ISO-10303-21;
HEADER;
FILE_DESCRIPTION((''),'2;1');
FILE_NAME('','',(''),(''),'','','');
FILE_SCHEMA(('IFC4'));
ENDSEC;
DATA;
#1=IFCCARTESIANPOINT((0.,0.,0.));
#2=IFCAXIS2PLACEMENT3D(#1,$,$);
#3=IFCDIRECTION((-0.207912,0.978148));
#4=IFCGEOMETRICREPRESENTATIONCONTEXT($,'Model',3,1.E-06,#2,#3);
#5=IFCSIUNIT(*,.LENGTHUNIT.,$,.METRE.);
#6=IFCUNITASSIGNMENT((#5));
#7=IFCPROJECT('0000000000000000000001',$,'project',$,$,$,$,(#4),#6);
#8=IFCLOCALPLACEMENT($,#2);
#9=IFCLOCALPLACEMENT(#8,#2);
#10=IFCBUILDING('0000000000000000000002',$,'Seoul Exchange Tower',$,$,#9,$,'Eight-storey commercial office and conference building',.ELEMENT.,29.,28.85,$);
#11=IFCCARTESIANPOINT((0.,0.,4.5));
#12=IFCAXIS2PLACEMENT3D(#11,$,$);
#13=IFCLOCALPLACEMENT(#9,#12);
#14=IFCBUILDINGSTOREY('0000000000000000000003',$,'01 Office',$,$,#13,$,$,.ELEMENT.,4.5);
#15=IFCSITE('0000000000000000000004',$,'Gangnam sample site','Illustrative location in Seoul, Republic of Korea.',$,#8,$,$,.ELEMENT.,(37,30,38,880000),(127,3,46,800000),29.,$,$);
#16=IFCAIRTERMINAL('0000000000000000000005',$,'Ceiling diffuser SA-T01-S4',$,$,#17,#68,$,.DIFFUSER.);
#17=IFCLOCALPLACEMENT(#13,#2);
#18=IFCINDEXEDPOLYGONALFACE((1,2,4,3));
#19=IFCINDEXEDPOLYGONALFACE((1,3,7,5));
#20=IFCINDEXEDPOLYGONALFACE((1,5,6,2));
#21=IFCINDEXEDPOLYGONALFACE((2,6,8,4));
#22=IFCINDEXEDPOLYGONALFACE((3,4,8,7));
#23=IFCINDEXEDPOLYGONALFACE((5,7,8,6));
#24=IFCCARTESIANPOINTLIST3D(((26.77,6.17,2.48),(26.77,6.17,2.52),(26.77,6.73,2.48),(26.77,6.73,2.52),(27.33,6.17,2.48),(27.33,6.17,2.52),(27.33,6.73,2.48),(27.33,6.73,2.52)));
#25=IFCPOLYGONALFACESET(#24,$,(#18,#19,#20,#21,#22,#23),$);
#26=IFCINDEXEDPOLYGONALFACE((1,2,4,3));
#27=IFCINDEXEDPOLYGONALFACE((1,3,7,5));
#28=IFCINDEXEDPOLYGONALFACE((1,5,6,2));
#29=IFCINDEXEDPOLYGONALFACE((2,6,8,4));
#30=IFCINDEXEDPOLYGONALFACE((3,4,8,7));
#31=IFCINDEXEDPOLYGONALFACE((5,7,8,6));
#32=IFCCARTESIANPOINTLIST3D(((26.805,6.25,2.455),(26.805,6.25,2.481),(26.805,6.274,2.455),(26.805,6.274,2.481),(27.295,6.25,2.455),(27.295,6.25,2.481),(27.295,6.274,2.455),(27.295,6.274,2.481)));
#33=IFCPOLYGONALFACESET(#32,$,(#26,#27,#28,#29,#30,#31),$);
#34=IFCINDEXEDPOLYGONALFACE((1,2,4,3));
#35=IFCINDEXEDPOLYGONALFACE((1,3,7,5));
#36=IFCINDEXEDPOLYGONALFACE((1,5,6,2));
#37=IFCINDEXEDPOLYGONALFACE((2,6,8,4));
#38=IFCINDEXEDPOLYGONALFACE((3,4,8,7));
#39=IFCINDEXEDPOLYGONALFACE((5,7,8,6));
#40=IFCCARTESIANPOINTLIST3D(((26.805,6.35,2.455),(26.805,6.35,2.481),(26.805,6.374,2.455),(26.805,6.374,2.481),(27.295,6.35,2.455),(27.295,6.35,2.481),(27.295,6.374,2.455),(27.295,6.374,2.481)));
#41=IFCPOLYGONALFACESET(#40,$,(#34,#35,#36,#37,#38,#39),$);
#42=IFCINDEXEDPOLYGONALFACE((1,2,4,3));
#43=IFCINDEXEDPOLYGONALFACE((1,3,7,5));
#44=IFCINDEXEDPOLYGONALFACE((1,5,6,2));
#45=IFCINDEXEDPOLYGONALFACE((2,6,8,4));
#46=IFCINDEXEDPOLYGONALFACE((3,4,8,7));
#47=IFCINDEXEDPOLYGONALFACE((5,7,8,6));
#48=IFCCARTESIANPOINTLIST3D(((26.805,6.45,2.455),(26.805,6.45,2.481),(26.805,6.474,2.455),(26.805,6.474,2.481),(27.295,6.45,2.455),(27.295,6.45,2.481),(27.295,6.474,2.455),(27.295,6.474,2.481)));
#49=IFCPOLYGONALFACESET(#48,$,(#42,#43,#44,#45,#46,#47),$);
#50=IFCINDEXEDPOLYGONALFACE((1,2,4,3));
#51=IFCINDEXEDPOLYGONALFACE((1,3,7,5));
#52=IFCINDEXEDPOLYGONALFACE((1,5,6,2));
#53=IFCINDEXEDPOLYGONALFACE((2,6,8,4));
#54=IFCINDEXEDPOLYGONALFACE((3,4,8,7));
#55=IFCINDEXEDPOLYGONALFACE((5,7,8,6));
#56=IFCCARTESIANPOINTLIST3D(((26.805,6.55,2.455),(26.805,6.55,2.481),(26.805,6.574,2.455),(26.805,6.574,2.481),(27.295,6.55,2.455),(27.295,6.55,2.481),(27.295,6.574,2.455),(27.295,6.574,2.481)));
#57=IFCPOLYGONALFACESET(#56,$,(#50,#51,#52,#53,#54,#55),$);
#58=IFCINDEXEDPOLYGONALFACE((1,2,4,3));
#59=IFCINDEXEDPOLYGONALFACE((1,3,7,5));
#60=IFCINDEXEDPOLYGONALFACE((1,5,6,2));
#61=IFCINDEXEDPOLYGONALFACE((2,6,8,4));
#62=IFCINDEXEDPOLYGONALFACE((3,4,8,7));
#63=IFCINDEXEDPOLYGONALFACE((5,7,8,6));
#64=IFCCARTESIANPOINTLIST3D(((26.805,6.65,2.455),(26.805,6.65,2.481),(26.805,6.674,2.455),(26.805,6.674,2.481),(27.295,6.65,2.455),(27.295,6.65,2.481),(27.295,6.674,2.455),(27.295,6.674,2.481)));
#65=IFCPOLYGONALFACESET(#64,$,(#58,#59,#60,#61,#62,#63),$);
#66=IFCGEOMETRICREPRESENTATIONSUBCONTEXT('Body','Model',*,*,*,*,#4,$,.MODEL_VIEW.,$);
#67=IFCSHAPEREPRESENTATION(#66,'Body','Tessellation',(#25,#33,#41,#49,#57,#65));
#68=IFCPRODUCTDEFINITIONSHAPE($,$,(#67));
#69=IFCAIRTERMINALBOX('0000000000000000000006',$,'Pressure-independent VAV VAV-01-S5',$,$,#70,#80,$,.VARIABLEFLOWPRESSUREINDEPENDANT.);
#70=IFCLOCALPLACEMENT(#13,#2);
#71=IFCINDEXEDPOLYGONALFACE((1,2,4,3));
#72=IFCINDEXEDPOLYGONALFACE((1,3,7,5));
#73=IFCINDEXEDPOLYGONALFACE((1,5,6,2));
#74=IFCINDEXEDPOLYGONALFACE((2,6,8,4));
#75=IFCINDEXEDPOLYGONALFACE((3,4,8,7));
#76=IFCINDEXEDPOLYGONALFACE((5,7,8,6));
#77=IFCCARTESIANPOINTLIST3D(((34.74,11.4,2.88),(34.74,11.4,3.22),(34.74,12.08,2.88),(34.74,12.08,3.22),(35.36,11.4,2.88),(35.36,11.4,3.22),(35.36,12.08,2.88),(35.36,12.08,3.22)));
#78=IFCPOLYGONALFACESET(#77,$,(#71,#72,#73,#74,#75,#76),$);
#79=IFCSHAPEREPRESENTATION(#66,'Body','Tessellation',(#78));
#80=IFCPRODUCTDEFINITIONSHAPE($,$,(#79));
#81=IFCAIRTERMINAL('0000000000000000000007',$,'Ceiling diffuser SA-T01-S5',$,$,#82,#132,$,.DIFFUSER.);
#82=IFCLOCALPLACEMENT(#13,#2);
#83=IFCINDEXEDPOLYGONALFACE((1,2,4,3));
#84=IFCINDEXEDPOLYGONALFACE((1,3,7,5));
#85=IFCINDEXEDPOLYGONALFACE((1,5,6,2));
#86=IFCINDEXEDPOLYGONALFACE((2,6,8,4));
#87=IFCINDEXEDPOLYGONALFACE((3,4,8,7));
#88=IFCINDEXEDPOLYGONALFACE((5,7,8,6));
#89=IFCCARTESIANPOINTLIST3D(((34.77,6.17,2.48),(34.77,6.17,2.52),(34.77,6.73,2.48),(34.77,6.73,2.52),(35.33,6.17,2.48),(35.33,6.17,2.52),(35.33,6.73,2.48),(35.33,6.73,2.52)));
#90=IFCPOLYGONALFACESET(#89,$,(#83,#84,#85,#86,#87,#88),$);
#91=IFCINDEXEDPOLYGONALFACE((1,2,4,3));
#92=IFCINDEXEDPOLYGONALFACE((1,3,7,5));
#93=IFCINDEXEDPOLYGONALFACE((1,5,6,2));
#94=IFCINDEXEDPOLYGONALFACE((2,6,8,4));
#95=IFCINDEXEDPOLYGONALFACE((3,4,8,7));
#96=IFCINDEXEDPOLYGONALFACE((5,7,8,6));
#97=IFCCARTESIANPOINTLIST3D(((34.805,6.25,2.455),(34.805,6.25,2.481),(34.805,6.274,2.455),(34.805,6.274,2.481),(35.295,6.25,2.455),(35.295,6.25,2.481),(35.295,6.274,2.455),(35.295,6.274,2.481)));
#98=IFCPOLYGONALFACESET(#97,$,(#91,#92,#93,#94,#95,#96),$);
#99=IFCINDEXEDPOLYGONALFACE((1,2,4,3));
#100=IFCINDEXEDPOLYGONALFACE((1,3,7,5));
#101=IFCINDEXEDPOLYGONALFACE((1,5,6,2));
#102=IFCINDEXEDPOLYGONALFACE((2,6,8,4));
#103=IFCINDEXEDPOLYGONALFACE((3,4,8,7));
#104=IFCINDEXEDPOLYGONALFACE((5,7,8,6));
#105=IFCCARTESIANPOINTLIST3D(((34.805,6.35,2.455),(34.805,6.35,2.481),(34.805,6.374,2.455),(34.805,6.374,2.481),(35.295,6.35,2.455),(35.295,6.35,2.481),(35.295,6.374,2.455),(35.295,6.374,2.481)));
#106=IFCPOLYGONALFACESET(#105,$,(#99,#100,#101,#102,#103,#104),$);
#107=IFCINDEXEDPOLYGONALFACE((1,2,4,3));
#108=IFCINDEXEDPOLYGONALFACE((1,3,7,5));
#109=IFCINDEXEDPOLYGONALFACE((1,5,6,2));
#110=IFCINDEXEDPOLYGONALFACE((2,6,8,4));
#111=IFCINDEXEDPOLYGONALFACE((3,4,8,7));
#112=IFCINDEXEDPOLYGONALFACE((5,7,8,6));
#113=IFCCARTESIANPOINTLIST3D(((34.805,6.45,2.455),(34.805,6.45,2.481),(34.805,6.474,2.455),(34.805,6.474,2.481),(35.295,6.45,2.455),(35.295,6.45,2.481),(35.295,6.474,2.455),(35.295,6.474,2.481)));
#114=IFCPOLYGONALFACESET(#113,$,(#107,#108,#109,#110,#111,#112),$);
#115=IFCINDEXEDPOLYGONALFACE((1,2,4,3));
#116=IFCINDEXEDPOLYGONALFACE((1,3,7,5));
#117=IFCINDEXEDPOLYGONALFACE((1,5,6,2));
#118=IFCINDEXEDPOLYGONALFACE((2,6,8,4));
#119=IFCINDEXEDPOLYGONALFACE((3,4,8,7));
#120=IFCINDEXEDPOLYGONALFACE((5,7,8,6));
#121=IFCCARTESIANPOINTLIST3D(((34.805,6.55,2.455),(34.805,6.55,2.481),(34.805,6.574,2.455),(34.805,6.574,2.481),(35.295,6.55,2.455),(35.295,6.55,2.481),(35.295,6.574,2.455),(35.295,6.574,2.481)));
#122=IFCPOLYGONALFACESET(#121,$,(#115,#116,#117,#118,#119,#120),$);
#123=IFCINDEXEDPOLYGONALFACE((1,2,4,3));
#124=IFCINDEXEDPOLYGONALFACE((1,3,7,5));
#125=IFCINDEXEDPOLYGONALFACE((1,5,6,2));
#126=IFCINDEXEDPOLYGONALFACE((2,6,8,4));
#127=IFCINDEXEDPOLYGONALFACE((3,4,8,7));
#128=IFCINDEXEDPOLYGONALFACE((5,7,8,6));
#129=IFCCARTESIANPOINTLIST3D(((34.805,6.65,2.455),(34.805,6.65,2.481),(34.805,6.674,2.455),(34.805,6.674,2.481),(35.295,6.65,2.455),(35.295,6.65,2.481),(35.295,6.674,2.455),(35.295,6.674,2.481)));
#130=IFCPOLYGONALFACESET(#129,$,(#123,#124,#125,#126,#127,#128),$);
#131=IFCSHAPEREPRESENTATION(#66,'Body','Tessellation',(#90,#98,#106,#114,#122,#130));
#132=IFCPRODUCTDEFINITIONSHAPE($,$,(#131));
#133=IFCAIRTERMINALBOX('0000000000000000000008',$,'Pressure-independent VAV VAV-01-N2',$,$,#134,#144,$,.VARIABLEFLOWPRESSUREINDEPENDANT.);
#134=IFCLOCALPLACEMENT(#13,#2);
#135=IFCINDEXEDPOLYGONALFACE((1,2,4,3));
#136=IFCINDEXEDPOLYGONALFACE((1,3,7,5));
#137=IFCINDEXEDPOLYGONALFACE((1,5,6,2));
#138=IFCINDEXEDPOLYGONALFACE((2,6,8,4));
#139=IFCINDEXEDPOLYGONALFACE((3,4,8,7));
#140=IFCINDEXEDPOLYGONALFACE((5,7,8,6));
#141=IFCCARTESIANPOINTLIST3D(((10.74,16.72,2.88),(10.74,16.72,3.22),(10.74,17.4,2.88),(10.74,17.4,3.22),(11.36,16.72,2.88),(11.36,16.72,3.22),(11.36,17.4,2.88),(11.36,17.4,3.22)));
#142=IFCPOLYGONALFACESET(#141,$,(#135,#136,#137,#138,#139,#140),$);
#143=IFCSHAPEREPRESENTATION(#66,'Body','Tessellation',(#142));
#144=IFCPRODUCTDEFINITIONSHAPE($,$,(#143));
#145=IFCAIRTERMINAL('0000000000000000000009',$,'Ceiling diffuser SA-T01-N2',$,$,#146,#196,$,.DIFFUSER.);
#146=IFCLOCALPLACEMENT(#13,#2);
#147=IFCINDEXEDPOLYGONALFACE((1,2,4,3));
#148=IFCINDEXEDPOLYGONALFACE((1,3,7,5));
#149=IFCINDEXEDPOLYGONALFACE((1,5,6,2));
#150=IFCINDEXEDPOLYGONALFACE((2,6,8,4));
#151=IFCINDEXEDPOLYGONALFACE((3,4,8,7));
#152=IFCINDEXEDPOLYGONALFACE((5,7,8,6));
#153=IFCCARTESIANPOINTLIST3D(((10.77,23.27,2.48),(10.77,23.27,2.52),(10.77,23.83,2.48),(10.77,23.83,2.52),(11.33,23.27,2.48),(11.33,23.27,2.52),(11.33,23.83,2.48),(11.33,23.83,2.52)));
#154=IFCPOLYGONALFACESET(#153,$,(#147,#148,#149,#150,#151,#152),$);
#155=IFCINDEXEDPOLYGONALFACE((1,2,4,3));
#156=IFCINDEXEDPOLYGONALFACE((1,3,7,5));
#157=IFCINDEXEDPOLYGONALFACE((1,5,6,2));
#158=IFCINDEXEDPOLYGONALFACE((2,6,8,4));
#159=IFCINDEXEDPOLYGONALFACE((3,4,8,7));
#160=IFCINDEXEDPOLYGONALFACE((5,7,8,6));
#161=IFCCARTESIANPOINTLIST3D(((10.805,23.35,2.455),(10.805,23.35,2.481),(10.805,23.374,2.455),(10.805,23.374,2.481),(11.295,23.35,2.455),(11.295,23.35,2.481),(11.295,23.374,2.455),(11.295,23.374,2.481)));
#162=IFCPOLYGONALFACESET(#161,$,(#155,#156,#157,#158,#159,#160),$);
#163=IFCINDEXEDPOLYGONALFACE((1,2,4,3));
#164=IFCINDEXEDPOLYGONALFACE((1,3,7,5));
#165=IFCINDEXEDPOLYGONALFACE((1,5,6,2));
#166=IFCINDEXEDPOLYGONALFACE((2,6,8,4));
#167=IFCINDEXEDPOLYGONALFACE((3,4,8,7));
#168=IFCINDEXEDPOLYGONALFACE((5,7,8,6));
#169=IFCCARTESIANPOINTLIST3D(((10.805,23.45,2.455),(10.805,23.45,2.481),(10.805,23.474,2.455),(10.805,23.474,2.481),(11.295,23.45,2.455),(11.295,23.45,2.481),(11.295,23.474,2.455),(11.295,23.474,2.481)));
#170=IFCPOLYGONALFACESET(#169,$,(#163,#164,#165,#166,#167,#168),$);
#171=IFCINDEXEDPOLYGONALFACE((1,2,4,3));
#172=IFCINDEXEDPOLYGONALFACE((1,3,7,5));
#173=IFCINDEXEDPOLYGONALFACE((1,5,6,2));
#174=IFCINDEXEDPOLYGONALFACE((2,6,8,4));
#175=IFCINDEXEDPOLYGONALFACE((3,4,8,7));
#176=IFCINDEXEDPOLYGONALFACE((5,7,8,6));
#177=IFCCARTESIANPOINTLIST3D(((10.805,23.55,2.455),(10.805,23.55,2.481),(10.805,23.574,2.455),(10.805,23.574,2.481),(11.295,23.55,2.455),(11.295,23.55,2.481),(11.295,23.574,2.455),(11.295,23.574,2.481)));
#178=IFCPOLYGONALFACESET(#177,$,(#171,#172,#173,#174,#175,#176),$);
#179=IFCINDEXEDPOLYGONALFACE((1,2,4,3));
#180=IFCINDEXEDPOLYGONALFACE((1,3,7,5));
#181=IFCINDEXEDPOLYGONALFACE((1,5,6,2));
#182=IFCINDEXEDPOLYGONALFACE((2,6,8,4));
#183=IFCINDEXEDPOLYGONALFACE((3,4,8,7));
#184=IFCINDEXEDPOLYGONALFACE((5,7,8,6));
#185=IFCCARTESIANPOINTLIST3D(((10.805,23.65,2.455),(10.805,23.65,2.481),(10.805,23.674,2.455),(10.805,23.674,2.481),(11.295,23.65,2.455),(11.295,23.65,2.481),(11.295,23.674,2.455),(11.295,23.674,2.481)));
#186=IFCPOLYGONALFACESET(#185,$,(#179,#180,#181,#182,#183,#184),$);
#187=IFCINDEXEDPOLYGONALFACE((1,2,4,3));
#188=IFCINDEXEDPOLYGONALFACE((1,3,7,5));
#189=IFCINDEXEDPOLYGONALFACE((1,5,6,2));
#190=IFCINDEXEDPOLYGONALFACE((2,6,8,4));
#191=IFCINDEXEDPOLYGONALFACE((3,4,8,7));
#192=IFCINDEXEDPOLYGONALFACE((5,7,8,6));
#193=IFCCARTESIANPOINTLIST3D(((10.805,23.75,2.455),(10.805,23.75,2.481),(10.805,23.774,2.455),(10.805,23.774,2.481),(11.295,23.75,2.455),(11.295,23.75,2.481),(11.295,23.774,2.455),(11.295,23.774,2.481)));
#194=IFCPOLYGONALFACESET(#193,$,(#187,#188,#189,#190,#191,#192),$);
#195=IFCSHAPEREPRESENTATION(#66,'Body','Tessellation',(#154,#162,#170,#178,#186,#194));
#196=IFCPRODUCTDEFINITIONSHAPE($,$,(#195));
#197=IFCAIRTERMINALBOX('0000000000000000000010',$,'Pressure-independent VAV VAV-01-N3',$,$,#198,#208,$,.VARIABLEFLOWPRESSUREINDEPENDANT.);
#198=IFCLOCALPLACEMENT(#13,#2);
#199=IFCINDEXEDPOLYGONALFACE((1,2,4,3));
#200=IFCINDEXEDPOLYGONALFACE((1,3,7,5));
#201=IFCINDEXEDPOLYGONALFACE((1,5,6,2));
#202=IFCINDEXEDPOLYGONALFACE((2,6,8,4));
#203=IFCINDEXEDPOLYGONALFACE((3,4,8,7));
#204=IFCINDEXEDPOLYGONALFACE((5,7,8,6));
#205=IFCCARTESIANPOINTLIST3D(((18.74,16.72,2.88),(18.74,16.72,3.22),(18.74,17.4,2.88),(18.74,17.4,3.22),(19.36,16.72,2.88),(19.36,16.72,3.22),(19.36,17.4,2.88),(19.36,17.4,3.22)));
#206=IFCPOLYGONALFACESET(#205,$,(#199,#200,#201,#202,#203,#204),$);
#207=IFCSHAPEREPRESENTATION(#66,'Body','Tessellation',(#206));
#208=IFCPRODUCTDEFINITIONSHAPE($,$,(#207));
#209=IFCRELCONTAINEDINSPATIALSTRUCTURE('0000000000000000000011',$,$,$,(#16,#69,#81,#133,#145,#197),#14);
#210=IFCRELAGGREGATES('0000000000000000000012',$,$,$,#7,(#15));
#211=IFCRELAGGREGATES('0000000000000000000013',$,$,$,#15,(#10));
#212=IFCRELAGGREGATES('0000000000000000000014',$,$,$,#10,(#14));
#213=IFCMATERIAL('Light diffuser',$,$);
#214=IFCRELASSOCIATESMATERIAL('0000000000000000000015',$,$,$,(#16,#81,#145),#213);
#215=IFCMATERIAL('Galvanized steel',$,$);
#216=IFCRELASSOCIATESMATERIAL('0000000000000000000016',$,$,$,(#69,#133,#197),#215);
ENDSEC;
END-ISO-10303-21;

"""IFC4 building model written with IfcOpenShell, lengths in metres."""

from ifc_helpers import new_model, si_unit, direction, frame, frame_2d, origin, place, context, subcontext, project, spatial, rectangle, extrude, material, element, save


model = new_model("IFC4")

# Units and contexts
model_context = context("Model", 3, precision=1e-06, world=origin(), true_north=direction((-0.207912, 0.978148)))
body_context = subcontext(model_context, "Body", "Model", "MODEL_VIEW")
ifc_project = project(units=[si_unit("LENGTHUNIT", "METRE")], contexts=[model_context])

# Site, building, storey
site_placement = place(None, origin())
site = spatial("IfcSite", under=ifc_project, at=site_placement, Name="Gangnam sample site", Description="Illustrative location in Seoul, Republic of Korea.", CompositionType="ELEMENT", RefLatitude=(37, 30, 38, 880000), RefLongitude=(127, 3, 46, 800000), RefElevation=29.0)
building_placement = place(site_placement, origin())
building = spatial("IfcBuilding", under=site, at=building_placement, Name="Seoul Exchange Tower", LongName="Eight-storey commercial office and conference building", CompositionType="ELEMENT", ElevationOfRefHeight=29.0, ElevationOfTerrain=28.85)
storey_placement = place(building_placement, frame((0.0, 0.0, 4.5)))
storey = spatial("IfcBuildingStorey", under=building, at=storey_placement, Name="01 Office", CompositionType="ELEMENT", Elevation=4.5)

# Shared definitions
placement = place(storey_placement, origin())

# Shared definitions
ifc_material_1 = material(Name="Galvanized steel")

# Shared definitions
ifc_material_2 = material(Name="Light diffuser")

# Air terminal
element("IfcAirTerminal", 1, at=placement, inside=storey, material=ifc_material_2, Name="Ceiling diffuser SA-T01-S4", PredefinedType="DIFFUSER", context=body_context, shape_type="SweptSolid", body=[
    extrude(rectangle(XDim=0.56, YDim=0.56, at=frame_2d((0.28, 0.28))), frame((26.77, 6.17, 2.48)), (0.0, 0.0, 1.0), 0.04),
    extrude(rectangle(XDim=0.49, YDim=0.024, at=frame_2d((0.245, 0.012))), frame((26.805, 6.25, 2.455)), (0.0, 0.0, 1.0), 0.026),
    extrude(rectangle(XDim=0.49, YDim=0.024, at=frame_2d((0.245, 0.012))), frame((26.805, 6.35, 2.455)), (0.0, 0.0, 1.0), 0.026),
    extrude(rectangle(XDim=0.49, YDim=0.024, at=frame_2d((0.245, 0.012))), frame((26.805, 6.45, 2.455)), (0.0, 0.0, 1.0), 0.026),
    extrude(rectangle(XDim=0.49, YDim=0.024, at=frame_2d((0.245, 0.012))), frame((26.805, 6.55, 2.455)), (0.0, 0.0, 1.0), 0.026),
    extrude(rectangle(XDim=0.49, YDim=0.024, at=frame_2d((0.245, 0.012))), frame((26.805, 6.65, 2.455)), (0.0, 0.0, 1.0), 0.026),
])

# Air terminal box
element("IfcAirTerminalBox", 2, at=placement, inside=storey, material=ifc_material_1, Name="Pressure-independent VAV VAV-01-S5", PredefinedType="VARIABLEFLOWPRESSUREINDEPENDANT", context=body_context, shape_type="SweptSolid", body=[
    extrude(rectangle(XDim=0.62, YDim=0.68, at=frame_2d((0.31, 0.34))), frame((34.74, 11.4, 2.88)), (0.0, 0.0, 1.0), 0.34),
])

# Air terminal
element("IfcAirTerminal", 3, at=placement, inside=storey, material=ifc_material_2, Name="Ceiling diffuser SA-T01-S5", PredefinedType="DIFFUSER", context=body_context, shape_type="SweptSolid", body=[
    extrude(rectangle(XDim=0.56, YDim=0.56, at=frame_2d((0.28, 0.28))), frame((34.77, 6.17, 2.48)), (0.0, 0.0, 1.0), 0.04),
    extrude(rectangle(XDim=0.49, YDim=0.024, at=frame_2d((0.245, 0.012))), frame((34.805, 6.25, 2.455)), (0.0, 0.0, 1.0), 0.026),
    extrude(rectangle(XDim=0.49, YDim=0.024, at=frame_2d((0.245, 0.012))), frame((34.805, 6.35, 2.455)), (0.0, 0.0, 1.0), 0.026),
    extrude(rectangle(XDim=0.49, YDim=0.024, at=frame_2d((0.245, 0.012))), frame((34.805, 6.45, 2.455)), (0.0, 0.0, 1.0), 0.026),
    extrude(rectangle(XDim=0.49, YDim=0.024, at=frame_2d((0.245, 0.012))), frame((34.805, 6.55, 2.455)), (0.0, 0.0, 1.0), 0.026),
    extrude(rectangle(XDim=0.49, YDim=0.024, at=frame_2d((0.245, 0.012))), frame((34.805, 6.65, 2.455)), (0.0, 0.0, 1.0), 0.026),
])

# Air terminal box
element("IfcAirTerminalBox", 4, at=placement, inside=storey, material=ifc_material_1, Name="Pressure-independent VAV VAV-01-N2", PredefinedType="VARIABLEFLOWPRESSUREINDEPENDANT", context=body_context, shape_type="SweptSolid", body=[
    extrude(rectangle(XDim=0.62, YDim=0.68, at=frame_2d((0.31, 0.34))), frame((10.74, 16.72, 2.88)), (0.0, 0.0, 1.0), 0.34),
])

# Air terminal
element("IfcAirTerminal", 5, at=placement, inside=storey, material=ifc_material_2, Name="Ceiling diffuser SA-T01-N2", PredefinedType="DIFFUSER", context=body_context, shape_type="SweptSolid", body=[
    extrude(rectangle(XDim=0.56, YDim=0.56, at=frame_2d((0.28, 0.28))), frame((10.77, 23.27, 2.48)), (0.0, 0.0, 1.0), 0.04),
    extrude(rectangle(XDim=0.49, YDim=0.024, at=frame_2d((0.245, 0.012))), frame((10.805, 23.35, 2.455)), (0.0, 0.0, 1.0), 0.026),
    extrude(rectangle(XDim=0.49, YDim=0.024, at=frame_2d((0.245, 0.012))), frame((10.805, 23.45, 2.455)), (0.0, 0.0, 1.0), 0.026),
    extrude(rectangle(XDim=0.49, YDim=0.024, at=frame_2d((0.245, 0.012))), frame((10.805, 23.55, 2.455)), (0.0, 0.0, 1.0), 0.026),
    extrude(rectangle(XDim=0.49, YDim=0.024, at=frame_2d((0.245, 0.012))), frame((10.805, 23.65, 2.455)), (0.0, 0.0, 1.0), 0.026),
    extrude(rectangle(XDim=0.49, YDim=0.024, at=frame_2d((0.245, 0.012))), frame((10.805, 23.75, 2.455)), (0.0, 0.0, 1.0), 0.026),
])

# Air terminal box
element("IfcAirTerminalBox", 6, at=placement, inside=storey, material=ifc_material_1, Name="Pressure-independent VAV VAV-01-N3", PredefinedType="VARIABLEFLOWPRESSUREINDEPENDANT", context=body_context, shape_type="SweptSolid", body=[
    extrude(rectangle(XDim=0.62, YDim=0.68, at=frame_2d((0.31, 0.34))), frame((18.74, 16.72, 2.88)), (0.0, 0.0, 1.0), 0.34),
])

save(model, "model.ifc")
